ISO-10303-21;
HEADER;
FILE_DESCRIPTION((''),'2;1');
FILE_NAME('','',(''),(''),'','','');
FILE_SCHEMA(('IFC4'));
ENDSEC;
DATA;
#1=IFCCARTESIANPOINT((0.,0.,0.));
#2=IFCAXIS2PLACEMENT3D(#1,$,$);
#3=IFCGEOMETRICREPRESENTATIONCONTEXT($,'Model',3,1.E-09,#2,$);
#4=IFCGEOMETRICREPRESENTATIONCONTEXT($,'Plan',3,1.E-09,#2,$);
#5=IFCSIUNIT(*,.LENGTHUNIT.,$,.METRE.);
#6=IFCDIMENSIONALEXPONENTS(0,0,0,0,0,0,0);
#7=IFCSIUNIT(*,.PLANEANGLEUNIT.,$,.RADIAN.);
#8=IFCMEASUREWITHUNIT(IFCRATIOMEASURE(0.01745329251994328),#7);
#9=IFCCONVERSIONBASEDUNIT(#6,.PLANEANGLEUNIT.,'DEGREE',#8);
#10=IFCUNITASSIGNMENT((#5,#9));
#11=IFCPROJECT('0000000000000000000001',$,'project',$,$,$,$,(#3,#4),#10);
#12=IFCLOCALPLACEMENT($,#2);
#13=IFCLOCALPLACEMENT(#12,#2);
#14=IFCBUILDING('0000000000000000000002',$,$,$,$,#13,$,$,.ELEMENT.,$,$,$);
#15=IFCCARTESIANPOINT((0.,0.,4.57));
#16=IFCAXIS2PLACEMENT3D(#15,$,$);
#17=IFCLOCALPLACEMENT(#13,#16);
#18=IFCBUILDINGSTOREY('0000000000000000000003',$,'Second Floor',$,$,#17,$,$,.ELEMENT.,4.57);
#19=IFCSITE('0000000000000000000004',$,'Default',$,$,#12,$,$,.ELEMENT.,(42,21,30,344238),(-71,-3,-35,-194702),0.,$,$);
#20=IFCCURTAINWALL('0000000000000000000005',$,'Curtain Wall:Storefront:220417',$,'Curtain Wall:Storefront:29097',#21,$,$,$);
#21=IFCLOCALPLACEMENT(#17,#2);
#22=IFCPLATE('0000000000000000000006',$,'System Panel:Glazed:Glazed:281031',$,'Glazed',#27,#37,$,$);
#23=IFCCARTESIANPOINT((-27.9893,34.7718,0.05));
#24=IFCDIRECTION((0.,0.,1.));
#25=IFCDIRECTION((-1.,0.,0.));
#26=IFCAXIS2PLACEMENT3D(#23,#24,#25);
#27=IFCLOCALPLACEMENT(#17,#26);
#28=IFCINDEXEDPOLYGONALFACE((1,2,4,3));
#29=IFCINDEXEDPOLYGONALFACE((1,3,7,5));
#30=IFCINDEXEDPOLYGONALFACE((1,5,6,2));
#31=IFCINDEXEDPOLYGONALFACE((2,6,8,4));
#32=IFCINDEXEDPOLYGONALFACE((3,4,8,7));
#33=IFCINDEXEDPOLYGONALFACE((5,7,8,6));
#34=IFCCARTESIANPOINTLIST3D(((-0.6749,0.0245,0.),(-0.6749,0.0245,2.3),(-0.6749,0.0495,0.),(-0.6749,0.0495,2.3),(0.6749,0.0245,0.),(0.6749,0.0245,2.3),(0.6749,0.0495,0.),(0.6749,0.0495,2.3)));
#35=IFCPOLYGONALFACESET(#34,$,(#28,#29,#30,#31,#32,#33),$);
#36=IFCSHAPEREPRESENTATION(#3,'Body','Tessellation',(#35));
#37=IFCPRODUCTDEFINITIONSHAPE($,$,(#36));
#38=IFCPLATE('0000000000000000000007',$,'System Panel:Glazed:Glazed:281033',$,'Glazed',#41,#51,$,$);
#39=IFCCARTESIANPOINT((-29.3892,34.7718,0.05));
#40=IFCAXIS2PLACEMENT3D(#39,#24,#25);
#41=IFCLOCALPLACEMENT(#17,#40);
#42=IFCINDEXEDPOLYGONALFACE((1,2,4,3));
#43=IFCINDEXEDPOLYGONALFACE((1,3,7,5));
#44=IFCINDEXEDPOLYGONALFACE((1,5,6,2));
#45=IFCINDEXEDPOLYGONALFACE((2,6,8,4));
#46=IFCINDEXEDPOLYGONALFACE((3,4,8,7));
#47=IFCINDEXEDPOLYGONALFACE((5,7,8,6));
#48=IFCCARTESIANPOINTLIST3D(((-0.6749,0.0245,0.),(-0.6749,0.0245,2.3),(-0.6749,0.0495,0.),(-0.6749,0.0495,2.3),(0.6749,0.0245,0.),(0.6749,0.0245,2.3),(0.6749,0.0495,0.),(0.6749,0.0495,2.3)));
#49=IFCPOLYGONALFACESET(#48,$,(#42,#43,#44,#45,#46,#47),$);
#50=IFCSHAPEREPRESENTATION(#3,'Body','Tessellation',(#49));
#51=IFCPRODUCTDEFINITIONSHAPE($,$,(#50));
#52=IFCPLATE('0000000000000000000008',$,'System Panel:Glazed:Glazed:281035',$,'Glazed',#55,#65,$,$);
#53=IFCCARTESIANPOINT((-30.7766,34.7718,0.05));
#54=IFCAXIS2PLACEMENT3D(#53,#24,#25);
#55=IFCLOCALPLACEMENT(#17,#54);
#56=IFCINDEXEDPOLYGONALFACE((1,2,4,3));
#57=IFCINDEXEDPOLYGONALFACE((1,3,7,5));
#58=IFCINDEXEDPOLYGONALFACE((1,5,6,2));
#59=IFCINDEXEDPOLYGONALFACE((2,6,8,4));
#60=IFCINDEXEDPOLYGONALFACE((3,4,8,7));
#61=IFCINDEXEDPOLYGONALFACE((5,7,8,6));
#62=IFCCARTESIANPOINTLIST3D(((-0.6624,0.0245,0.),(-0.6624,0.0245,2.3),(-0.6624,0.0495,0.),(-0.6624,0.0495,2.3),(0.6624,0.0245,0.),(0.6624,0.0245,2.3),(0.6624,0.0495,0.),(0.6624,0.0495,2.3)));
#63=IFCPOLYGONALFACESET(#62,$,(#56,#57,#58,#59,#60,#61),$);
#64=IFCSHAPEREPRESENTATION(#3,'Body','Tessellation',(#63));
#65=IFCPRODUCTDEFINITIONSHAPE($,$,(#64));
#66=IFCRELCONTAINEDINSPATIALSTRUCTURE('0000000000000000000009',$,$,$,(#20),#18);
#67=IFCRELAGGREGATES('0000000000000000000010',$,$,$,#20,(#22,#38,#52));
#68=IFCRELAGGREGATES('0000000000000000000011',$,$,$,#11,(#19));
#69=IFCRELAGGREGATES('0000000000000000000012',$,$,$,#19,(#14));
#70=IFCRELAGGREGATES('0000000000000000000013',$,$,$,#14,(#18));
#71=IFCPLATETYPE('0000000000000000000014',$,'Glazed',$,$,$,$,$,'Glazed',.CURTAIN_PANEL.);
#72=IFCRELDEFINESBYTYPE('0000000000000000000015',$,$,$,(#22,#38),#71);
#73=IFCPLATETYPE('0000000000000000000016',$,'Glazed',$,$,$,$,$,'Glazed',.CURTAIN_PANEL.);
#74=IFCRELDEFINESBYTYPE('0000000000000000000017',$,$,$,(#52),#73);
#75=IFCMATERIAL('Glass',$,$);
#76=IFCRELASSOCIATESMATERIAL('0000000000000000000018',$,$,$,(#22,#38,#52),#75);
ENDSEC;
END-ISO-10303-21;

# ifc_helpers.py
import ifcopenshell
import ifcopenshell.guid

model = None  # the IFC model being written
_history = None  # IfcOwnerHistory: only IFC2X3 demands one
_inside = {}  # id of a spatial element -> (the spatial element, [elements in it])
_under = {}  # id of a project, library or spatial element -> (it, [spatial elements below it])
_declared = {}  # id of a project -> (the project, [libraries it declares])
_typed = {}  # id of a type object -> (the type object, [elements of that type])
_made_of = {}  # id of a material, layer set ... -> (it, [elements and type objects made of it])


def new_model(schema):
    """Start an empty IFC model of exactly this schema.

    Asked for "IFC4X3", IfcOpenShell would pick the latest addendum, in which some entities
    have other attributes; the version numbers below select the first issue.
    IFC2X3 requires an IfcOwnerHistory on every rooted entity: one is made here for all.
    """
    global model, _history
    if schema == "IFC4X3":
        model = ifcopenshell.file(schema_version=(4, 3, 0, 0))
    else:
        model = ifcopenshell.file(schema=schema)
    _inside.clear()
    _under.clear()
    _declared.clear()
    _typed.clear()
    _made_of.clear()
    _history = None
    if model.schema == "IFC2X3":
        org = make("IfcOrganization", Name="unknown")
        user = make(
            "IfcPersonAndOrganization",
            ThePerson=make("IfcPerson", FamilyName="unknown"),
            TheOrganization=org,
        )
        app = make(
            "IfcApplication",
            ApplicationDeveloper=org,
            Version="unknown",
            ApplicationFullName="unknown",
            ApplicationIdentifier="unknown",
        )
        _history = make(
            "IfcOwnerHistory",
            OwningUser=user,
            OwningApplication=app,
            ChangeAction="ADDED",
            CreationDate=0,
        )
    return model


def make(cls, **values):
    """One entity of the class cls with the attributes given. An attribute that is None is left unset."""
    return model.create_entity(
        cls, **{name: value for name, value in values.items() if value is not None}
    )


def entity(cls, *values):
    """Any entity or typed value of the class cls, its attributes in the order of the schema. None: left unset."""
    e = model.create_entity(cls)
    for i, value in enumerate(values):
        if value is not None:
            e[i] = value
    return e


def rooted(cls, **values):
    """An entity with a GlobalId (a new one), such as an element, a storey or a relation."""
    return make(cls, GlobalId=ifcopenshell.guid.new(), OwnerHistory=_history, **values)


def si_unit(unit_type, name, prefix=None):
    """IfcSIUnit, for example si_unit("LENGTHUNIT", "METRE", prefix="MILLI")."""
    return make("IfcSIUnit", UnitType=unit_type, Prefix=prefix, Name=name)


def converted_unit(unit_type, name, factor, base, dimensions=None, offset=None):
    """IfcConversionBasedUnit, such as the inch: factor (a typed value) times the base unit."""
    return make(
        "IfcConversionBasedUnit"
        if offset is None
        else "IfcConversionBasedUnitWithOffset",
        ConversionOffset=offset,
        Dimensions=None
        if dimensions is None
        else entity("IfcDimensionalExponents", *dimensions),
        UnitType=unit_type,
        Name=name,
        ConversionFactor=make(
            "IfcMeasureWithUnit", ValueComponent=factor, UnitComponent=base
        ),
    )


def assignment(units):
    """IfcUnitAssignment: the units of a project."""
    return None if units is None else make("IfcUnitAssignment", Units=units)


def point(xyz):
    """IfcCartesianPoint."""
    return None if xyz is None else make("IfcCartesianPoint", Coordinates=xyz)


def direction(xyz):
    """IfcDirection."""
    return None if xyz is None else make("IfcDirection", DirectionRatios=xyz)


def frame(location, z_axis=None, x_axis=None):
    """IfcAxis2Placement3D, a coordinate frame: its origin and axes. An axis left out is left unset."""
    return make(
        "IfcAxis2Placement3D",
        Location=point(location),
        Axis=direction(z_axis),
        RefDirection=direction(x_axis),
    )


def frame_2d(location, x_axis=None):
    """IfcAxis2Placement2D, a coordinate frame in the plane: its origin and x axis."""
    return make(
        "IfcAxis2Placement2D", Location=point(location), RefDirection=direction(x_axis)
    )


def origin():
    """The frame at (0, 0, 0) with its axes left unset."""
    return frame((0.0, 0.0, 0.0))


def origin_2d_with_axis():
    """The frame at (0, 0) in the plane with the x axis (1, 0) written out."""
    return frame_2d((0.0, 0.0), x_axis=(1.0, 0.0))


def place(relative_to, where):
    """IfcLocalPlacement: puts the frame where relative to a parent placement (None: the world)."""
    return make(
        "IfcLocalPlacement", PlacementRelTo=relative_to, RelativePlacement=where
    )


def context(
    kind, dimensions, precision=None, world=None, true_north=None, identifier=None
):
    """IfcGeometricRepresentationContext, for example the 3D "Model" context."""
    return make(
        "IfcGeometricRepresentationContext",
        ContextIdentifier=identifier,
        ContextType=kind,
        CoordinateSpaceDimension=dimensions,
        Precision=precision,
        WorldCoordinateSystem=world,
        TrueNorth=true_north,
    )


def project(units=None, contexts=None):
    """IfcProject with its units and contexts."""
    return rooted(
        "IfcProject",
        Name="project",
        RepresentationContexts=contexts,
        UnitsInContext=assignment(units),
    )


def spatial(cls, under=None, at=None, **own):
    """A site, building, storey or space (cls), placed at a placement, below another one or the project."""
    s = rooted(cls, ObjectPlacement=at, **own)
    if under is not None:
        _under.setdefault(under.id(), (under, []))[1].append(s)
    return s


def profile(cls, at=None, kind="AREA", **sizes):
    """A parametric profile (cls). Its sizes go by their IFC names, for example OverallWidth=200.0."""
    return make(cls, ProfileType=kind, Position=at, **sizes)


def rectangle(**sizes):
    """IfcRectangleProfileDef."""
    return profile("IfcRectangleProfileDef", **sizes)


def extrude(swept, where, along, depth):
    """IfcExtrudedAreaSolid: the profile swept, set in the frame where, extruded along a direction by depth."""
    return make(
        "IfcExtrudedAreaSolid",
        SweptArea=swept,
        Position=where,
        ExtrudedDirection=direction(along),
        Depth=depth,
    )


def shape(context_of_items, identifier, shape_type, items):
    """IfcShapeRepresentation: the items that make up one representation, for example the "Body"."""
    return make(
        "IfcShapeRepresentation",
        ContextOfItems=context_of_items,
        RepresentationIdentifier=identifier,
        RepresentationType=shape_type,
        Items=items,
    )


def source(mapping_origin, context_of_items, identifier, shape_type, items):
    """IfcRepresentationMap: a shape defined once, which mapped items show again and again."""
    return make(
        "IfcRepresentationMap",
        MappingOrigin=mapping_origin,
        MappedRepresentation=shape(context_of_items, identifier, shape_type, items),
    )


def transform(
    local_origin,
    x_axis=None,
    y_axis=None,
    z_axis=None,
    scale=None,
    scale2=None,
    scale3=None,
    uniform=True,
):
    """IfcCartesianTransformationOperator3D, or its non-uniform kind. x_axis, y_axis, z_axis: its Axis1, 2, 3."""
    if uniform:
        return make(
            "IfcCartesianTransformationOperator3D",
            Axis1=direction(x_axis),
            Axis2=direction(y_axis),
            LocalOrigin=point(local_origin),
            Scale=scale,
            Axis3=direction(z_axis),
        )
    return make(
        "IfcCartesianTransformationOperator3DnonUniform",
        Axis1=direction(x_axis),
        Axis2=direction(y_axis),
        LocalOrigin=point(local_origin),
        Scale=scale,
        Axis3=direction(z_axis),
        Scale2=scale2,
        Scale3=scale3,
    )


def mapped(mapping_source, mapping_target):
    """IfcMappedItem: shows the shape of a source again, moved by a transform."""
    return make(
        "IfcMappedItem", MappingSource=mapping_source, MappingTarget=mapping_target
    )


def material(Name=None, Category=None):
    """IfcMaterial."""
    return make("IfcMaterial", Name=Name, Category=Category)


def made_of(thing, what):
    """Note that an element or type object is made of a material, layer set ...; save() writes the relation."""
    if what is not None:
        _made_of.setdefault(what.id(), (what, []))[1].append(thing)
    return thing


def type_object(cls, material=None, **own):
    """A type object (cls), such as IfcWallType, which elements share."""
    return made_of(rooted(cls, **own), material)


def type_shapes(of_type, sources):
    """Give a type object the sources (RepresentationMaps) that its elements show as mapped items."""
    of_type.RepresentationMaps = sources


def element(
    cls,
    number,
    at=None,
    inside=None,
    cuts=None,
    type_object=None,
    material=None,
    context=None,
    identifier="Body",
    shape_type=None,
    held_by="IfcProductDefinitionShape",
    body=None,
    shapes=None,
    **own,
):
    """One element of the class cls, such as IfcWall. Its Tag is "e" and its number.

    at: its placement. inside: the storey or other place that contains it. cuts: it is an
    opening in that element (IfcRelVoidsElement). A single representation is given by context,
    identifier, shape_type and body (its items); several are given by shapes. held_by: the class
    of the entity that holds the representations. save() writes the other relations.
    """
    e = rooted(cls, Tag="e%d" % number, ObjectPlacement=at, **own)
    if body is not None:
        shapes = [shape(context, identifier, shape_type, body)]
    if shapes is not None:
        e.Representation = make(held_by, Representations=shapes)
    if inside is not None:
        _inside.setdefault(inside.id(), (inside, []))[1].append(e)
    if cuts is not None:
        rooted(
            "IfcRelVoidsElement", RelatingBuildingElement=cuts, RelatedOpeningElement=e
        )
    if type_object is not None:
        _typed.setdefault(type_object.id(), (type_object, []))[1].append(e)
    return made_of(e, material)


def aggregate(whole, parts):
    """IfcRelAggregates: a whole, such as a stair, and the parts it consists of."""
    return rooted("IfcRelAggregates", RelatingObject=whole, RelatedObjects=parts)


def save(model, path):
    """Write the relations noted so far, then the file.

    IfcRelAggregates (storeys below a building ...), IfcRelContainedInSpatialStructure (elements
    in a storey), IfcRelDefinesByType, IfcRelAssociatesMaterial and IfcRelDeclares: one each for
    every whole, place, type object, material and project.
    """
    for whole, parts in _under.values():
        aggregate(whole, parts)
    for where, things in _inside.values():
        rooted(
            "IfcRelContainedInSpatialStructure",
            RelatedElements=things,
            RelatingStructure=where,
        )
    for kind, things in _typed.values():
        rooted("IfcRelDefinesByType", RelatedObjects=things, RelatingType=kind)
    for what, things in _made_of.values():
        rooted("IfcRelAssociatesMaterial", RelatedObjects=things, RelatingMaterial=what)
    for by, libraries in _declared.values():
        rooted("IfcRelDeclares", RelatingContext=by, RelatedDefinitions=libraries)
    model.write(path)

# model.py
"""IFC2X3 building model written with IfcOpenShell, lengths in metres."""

from ifc_helpers import new_model, entity, si_unit, converted_unit, frame, origin, origin_2d_with_axis, place, context, project, spatial, rectangle, extrude, source, transform, mapped, material, type_object, type_shapes, element, aggregate, save


model = new_model("IFC2X3")

# Units and contexts
model_context = context("Model", 3, precision=1e-09, world=origin())
plan_context = context("Plan", 3, precision=1e-09, world=origin())
ifc_project = project(units=[si_unit("LENGTHUNIT", "METRE"), converted_unit("PLANEANGLEUNIT", "DEGREE", entity("IfcRatioMeasure", 0.01745329251994328), si_unit("PLANEANGLEUNIT", "RADIAN"), dimensions=[0, 0, 0, 0, 0, 0, 0])], contexts=[model_context, plan_context])

# Site, building, storey
site_placement = place(None, origin())
site = spatial("IfcSite", under=ifc_project, at=site_placement, Name="Default", CompositionType="ELEMENT", RefLatitude=(42, 21, 30, 344238), RefLongitude=(-71, -3, -35, -194702), RefElevation=0.0)
building_placement = place(site_placement, origin())
building = spatial("IfcBuilding", under=site, at=building_placement, CompositionType="ELEMENT")
storey_placement = place(building_placement, frame((0.0, 0.0, 4.57)))
storey = spatial("IfcBuildingStorey", under=building, at=storey_placement, Name="Second Floor", CompositionType="ELEMENT", Elevation=4.57)

# Curtain wall, plates
curtain_wall_placement = place(storey_placement, origin())
curtain_wall = element("IfcCurtainWall", 1, at=curtain_wall_placement, inside=storey, Name="Curtain Wall:Storefront:220417", ObjectType="Curtain Wall:Storefront:29097")
ifc_material_1 = material(Name="Glass")
plate_type_1 = type_object("IfcPlateType", Name="Glazed", ElementType="Glazed", PredefinedType="CURTAIN_PANEL")
shared_shape_1 = source(origin(), model_context, "Body", "SweptSolid", [
    extrude(rectangle(XDim=0.025, YDim=1.3499, at=origin_2d_with_axis()), frame((0.0, 0.037, 0.0), z_axis=(0.0, 0.0, 1.0), x_axis=(0.0, 1.0, 0.0)), (0.0, 0.0, 1.0), 2.3),
])
type_shapes(plate_type_1, [shared_shape_1])
plate_1_placement = place(storey_placement, frame((-27.9893, 34.7718, 0.05), z_axis=(0.0, 0.0, 1.0), x_axis=(-1.0, 0.0, 0.0)))
plate_1 = element("IfcPlate", 2, at=plate_1_placement, type_object=plate_type_1, material=ifc_material_1, Name="System Panel:Glazed:Glazed:281031", ObjectType="Glazed", context=model_context, shape_type="MappedRepresentation", body=[
    mapped(shared_shape_1, transform((0.0, 0.0, 0.0), scale=1.0)),
])
plate_2_placement = place(storey_placement, frame((-29.3892, 34.7718, 0.05), z_axis=(0.0, 0.0, 1.0), x_axis=(-1.0, 0.0, 0.0)))
plate_2 = element("IfcPlate", 3, at=plate_2_placement, type_object=plate_type_1, material=ifc_material_1, Name="System Panel:Glazed:Glazed:281033", ObjectType="Glazed", context=model_context, shape_type="MappedRepresentation", body=[
    mapped(shared_shape_1, transform((0.0, 0.0, 0.0), scale=1.0)),
])
plate_type_2 = type_object("IfcPlateType", Name="Glazed", ElementType="Glazed", PredefinedType="CURTAIN_PANEL")
shared_shape_2 = source(origin(), model_context, "Body", "SweptSolid", [
    extrude(rectangle(XDim=0.025, YDim=1.3249, at=origin_2d_with_axis()), frame((0.0, 0.037, 0.0), z_axis=(0.0, 0.0, 1.0), x_axis=(0.0, 1.0, 0.0)), (0.0, 0.0, 1.0), 2.3),
])
type_shapes(plate_type_2, [shared_shape_2])
plate_3_placement = place(storey_placement, frame((-30.7766, 34.7718, 0.05), z_axis=(0.0, 0.0, 1.0), x_axis=(-1.0, 0.0, 0.0)))
plate_3 = element("IfcPlate", 4, at=plate_3_placement, type_object=plate_type_2, material=ifc_material_1, Name="System Panel:Glazed:Glazed:281035", ObjectType="Glazed", context=model_context, shape_type="MappedRepresentation", body=[
    mapped(shared_shape_2, transform((0.0, 0.0, 0.0), scale=1.0)),
])
aggregate(curtain_wall, [plate_1, plate_2, plate_3])

save(model, "model.ifc")
